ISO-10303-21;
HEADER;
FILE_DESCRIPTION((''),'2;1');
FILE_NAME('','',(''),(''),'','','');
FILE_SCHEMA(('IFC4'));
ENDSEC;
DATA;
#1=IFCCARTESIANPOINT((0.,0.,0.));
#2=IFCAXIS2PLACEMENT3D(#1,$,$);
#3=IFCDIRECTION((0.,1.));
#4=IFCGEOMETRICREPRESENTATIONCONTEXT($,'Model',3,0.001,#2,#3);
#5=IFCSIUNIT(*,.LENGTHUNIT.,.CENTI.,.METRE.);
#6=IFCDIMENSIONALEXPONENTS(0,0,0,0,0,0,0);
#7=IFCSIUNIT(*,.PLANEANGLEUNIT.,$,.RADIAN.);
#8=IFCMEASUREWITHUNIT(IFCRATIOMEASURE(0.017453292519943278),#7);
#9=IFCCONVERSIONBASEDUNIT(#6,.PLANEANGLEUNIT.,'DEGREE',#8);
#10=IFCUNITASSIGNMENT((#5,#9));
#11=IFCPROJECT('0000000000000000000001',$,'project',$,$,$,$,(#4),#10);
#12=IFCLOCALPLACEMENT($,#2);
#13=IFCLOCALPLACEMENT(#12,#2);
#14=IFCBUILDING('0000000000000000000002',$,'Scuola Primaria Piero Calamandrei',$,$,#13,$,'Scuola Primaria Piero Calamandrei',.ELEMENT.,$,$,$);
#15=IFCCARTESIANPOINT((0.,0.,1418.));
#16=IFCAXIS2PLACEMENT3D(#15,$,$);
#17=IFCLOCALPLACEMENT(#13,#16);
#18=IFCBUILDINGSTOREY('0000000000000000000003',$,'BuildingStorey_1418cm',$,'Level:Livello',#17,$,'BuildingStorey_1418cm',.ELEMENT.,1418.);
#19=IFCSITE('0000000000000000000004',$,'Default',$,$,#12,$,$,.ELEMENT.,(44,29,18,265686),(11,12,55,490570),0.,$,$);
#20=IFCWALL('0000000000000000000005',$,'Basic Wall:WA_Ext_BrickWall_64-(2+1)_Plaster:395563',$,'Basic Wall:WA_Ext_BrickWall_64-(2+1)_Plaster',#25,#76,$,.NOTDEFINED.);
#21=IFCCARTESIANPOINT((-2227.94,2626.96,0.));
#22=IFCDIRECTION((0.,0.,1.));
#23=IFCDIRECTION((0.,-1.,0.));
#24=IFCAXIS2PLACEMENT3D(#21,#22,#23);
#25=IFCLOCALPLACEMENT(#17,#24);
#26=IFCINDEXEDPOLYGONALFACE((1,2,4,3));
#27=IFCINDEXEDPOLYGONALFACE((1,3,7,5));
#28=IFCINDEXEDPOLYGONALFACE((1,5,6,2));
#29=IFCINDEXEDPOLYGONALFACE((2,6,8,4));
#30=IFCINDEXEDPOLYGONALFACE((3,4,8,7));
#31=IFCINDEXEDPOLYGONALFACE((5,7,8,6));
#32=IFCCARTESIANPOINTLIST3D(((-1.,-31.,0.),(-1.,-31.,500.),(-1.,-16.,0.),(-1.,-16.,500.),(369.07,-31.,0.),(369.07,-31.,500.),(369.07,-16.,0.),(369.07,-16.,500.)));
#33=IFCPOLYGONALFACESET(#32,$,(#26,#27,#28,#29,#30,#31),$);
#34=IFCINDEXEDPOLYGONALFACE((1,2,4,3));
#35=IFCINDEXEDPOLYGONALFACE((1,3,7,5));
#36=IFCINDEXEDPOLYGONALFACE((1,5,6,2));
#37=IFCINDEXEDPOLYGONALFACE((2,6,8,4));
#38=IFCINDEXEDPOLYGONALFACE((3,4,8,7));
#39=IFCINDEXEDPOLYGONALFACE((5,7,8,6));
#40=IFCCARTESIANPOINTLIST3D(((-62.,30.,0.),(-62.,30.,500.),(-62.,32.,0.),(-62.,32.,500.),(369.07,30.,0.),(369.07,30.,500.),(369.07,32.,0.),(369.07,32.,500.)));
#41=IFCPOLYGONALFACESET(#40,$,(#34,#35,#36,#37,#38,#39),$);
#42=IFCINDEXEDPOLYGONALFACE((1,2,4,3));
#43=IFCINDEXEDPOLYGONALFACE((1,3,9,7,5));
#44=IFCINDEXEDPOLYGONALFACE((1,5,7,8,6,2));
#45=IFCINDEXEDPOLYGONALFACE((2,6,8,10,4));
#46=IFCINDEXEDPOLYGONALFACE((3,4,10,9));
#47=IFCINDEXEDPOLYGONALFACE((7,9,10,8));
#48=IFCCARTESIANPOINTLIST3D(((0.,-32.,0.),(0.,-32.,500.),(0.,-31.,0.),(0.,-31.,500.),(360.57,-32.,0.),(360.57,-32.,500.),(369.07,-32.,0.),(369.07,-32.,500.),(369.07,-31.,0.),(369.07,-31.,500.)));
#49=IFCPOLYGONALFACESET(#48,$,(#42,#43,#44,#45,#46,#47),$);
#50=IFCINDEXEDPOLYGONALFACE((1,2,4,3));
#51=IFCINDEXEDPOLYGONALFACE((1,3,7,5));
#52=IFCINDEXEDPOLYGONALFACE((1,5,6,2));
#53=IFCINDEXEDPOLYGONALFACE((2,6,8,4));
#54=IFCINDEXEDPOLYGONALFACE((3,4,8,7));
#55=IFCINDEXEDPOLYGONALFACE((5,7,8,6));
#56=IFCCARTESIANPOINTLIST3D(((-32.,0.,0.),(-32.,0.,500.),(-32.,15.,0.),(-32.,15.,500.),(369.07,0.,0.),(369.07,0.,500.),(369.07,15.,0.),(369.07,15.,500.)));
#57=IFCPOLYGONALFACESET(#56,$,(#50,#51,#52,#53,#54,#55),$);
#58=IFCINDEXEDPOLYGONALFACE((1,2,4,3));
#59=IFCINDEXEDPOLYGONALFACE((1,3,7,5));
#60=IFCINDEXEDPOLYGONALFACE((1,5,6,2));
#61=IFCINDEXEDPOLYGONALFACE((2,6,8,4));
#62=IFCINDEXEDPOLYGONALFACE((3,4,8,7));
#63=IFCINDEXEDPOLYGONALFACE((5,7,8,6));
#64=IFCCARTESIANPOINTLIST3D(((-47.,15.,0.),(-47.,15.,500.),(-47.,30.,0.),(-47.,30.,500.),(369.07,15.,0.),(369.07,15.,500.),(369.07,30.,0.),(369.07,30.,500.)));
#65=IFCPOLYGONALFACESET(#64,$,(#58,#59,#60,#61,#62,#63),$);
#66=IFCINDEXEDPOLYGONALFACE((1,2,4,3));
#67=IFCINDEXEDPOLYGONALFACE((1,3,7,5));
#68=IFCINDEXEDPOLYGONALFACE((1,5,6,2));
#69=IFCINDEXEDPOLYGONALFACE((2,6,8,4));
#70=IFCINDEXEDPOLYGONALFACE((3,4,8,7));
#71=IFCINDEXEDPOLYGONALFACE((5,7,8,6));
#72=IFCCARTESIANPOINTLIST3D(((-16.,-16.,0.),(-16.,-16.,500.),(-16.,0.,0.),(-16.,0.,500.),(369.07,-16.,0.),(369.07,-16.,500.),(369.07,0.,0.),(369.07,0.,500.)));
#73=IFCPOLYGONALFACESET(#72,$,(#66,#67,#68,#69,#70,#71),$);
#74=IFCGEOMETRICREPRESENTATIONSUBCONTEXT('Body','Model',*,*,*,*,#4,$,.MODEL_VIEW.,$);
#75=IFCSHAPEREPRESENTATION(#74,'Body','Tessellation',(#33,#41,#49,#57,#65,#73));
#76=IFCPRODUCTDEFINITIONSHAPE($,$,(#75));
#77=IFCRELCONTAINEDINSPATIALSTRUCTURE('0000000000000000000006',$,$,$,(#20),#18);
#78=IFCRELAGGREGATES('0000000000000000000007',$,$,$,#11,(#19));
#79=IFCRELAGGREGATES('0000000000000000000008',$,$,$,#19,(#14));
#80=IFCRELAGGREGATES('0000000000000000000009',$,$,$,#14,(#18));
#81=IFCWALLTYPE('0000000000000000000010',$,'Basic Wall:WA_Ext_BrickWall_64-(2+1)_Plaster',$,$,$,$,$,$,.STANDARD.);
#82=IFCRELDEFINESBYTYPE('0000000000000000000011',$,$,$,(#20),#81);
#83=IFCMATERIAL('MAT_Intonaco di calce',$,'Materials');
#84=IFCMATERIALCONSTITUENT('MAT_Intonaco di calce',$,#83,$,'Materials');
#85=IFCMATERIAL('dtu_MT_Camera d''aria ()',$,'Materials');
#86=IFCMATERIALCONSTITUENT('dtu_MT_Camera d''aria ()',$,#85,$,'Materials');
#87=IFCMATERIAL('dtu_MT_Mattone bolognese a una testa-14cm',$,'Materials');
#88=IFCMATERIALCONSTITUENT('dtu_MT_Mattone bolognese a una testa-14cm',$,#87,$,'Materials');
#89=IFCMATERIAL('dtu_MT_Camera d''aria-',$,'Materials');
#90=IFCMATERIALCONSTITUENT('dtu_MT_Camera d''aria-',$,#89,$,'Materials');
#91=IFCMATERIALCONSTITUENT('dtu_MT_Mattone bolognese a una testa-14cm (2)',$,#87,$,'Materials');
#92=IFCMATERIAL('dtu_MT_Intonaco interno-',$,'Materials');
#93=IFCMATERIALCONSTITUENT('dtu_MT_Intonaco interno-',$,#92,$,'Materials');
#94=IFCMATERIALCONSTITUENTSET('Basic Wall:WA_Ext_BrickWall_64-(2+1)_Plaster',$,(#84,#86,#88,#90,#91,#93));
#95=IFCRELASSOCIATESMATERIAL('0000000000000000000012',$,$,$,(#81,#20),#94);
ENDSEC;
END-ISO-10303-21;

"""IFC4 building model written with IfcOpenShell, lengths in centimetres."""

from ifc_helpers import new_model, entity, si_unit, converted_unit, direction, frame, origin, place, context, subcontext, project, spatial, indexed_curve, outline, extrude, material, constituent, constituent_set, type_object, element, save


model = new_model("IFC4")

# Units and contexts
model_context = context("Model", 3, precision=0.001, world=origin(), true_north=direction((0.0, 1.0)))
body_context = subcontext(model_context, "Body", "Model", "MODEL_VIEW")
ifc_project = project(units=[si_unit("LENGTHUNIT", "METRE", prefix="CENTI"), converted_unit("PLANEANGLEUNIT", "DEGREE", entity("IfcRatioMeasure", 0.017453292519943278), si_unit("PLANEANGLEUNIT", "RADIAN"), dimensions=[0, 0, 0, 0, 0, 0, 0])], contexts=[model_context])

# Site, building, storey
site_placement = place(None, origin())
site = spatial("IfcSite", under=ifc_project, at=site_placement, Name="Default", CompositionType="ELEMENT", RefLatitude=(44, 29, 18, 265686), RefLongitude=(11, 12, 55, 490570), RefElevation=0.0)
building_placement = place(site_placement, origin())
building = spatial("IfcBuilding", under=site, at=building_placement, Name="Scuola Primaria Piero Calamandrei", LongName="Scuola Primaria Piero Calamandrei", CompositionType="ELEMENT")
storey_placement = place(building_placement, frame((0.0, 0.0, 1418.0)))
storey = spatial("IfcBuildingStorey", under=building, at=storey_placement, Name="BuildingStorey_1418cm", ObjectType="Level:Livello", LongName="BuildingStorey_1418cm", CompositionType="ELEMENT", Elevation=1418.0)

# Shared definitions
ifc_material_1 = material(Name="dtu_MT_Intonaco interno-", Category="Materials")

# Wall
ifc_material_2 = material(Name="MAT_Intonaco di calce", Category="Materials")
ifc_constituent_1 = constituent(ifc_material_2, Name="MAT_Intonaco di calce", Category="Materials")
ifc_material_3 = material(Name="dtu_MT_Camera d'aria ()", Category="Materials")
ifc_constituent_2 = constituent(ifc_material_3, Name="dtu_MT_Camera d'aria ()", Category="Materials")
ifc_material_4 = material(Name="dtu_MT_Mattone bolognese a una testa-14cm", Category="Materials")
ifc_constituent_3 = constituent(ifc_material_4, Name="dtu_MT_Mattone bolognese a una testa-14cm", Category="Materials")
ifc_material_5 = material(Name="dtu_MT_Camera d'aria-", Category="Materials")
ifc_constituent_4 = constituent(ifc_material_5, Name="dtu_MT_Camera d'aria-", Category="Materials")
ifc_constituent_5 = constituent(ifc_material_4, Name="dtu_MT_Mattone bolognese a una testa-14cm (2)", Category="Materials")
ifc_constituent_6 = constituent(ifc_material_1, Name="dtu_MT_Intonaco interno-", Category="Materials")
ifc_constituent_set_1 = constituent_set(constituents=[ifc_constituent_1, ifc_constituent_2, ifc_constituent_3, ifc_constituent_4, ifc_constituent_5, ifc_constituent_6], Name="Basic Wall:WA_Ext_BrickWall_64-(2+1)_Plaster")
wall_type_1 = type_object("IfcWallType", Name="Basic Wall:WA_Ext_BrickWall_64-(2+1)_Plaster", PredefinedType="STANDARD", material=ifc_constituent_set_1)
wall_1_placement = place(storey_placement, frame((-2227.94, 2626.96, 0.0), z_axis=(0.0, 0.0, 1.0), x_axis=(0.0, -1.0, 0.0)))
element("IfcWall", 1, at=wall_1_placement, inside=storey, type_object=wall_type_1, material=ifc_constituent_set_1, Name="Basic Wall:WA_Ext_BrickWall_64-(2+1)_Plaster:395563", ObjectType="Basic Wall:WA_Ext_BrickWall_64-(2+1)_Plaster", PredefinedType="NOTDEFINED", context=body_context, shape_type="SweptSolid", body=[
    extrude(outline(indexed_curve([(-185.04, -7.5), (185.04, -7.5), (185.04, 7.5), (-185.04, 7.5), (-185.04, -7.5)], self_intersect=False)), frame((184.04, -23.5, 0.0)), (0.0, 0.0, 1.0), 500.0),
    extrude(outline(indexed_curve([(-1.0, -215.54), (1.0, -215.54), (1.0, 215.54), (-1.0, 215.54), (-1.0, -215.54)], self_intersect=False)), frame((153.54, 31.0, 0.0), z_axis=(0.0, 0.0, 1.0), x_axis=(0.0, -1.0, 0.0)), (0.0, 0.0, 1.0), 500.0),
    extrude(outline(indexed_curve([(140.83, -0.4), (149.33, -0.4), (149.33, 0.6), (-219.74, 0.6), (-219.74, -0.4), (140.83, -0.4)], self_intersect=False)), frame((219.74, -31.6, 0.0)), (0.0, 0.0, 1.0), 500.0),
    extrude(outline(indexed_curve([(-200.54, -7.5), (200.54, -7.5), (200.54, 7.5), (-200.54, 7.5), (-200.54, -7.5)], self_intersect=False)), frame((168.54, 7.5, 0.0)), (0.0, 0.0, 1.0), 500.0),
    extrude(outline(indexed_curve([(-208.04, -7.5), (208.04, -7.5), (208.04, 7.5), (-208.04, 7.5), (-208.04, -7.5)], self_intersect=False)), frame((161.04, 22.5, 0.0)), (0.0, 0.0, 1.0), 500.0),
    extrude(outline(indexed_curve([(-192.54, -8.0), (192.54, -8.0), (192.54, 8.0), (-192.54, 8.0), (-192.54, -8.0)], self_intersect=False)), frame((176.54, -8.0, 0.0)), (0.0, 0.0, 1.0), 500.0),
])

save(model, "model.ifc")
